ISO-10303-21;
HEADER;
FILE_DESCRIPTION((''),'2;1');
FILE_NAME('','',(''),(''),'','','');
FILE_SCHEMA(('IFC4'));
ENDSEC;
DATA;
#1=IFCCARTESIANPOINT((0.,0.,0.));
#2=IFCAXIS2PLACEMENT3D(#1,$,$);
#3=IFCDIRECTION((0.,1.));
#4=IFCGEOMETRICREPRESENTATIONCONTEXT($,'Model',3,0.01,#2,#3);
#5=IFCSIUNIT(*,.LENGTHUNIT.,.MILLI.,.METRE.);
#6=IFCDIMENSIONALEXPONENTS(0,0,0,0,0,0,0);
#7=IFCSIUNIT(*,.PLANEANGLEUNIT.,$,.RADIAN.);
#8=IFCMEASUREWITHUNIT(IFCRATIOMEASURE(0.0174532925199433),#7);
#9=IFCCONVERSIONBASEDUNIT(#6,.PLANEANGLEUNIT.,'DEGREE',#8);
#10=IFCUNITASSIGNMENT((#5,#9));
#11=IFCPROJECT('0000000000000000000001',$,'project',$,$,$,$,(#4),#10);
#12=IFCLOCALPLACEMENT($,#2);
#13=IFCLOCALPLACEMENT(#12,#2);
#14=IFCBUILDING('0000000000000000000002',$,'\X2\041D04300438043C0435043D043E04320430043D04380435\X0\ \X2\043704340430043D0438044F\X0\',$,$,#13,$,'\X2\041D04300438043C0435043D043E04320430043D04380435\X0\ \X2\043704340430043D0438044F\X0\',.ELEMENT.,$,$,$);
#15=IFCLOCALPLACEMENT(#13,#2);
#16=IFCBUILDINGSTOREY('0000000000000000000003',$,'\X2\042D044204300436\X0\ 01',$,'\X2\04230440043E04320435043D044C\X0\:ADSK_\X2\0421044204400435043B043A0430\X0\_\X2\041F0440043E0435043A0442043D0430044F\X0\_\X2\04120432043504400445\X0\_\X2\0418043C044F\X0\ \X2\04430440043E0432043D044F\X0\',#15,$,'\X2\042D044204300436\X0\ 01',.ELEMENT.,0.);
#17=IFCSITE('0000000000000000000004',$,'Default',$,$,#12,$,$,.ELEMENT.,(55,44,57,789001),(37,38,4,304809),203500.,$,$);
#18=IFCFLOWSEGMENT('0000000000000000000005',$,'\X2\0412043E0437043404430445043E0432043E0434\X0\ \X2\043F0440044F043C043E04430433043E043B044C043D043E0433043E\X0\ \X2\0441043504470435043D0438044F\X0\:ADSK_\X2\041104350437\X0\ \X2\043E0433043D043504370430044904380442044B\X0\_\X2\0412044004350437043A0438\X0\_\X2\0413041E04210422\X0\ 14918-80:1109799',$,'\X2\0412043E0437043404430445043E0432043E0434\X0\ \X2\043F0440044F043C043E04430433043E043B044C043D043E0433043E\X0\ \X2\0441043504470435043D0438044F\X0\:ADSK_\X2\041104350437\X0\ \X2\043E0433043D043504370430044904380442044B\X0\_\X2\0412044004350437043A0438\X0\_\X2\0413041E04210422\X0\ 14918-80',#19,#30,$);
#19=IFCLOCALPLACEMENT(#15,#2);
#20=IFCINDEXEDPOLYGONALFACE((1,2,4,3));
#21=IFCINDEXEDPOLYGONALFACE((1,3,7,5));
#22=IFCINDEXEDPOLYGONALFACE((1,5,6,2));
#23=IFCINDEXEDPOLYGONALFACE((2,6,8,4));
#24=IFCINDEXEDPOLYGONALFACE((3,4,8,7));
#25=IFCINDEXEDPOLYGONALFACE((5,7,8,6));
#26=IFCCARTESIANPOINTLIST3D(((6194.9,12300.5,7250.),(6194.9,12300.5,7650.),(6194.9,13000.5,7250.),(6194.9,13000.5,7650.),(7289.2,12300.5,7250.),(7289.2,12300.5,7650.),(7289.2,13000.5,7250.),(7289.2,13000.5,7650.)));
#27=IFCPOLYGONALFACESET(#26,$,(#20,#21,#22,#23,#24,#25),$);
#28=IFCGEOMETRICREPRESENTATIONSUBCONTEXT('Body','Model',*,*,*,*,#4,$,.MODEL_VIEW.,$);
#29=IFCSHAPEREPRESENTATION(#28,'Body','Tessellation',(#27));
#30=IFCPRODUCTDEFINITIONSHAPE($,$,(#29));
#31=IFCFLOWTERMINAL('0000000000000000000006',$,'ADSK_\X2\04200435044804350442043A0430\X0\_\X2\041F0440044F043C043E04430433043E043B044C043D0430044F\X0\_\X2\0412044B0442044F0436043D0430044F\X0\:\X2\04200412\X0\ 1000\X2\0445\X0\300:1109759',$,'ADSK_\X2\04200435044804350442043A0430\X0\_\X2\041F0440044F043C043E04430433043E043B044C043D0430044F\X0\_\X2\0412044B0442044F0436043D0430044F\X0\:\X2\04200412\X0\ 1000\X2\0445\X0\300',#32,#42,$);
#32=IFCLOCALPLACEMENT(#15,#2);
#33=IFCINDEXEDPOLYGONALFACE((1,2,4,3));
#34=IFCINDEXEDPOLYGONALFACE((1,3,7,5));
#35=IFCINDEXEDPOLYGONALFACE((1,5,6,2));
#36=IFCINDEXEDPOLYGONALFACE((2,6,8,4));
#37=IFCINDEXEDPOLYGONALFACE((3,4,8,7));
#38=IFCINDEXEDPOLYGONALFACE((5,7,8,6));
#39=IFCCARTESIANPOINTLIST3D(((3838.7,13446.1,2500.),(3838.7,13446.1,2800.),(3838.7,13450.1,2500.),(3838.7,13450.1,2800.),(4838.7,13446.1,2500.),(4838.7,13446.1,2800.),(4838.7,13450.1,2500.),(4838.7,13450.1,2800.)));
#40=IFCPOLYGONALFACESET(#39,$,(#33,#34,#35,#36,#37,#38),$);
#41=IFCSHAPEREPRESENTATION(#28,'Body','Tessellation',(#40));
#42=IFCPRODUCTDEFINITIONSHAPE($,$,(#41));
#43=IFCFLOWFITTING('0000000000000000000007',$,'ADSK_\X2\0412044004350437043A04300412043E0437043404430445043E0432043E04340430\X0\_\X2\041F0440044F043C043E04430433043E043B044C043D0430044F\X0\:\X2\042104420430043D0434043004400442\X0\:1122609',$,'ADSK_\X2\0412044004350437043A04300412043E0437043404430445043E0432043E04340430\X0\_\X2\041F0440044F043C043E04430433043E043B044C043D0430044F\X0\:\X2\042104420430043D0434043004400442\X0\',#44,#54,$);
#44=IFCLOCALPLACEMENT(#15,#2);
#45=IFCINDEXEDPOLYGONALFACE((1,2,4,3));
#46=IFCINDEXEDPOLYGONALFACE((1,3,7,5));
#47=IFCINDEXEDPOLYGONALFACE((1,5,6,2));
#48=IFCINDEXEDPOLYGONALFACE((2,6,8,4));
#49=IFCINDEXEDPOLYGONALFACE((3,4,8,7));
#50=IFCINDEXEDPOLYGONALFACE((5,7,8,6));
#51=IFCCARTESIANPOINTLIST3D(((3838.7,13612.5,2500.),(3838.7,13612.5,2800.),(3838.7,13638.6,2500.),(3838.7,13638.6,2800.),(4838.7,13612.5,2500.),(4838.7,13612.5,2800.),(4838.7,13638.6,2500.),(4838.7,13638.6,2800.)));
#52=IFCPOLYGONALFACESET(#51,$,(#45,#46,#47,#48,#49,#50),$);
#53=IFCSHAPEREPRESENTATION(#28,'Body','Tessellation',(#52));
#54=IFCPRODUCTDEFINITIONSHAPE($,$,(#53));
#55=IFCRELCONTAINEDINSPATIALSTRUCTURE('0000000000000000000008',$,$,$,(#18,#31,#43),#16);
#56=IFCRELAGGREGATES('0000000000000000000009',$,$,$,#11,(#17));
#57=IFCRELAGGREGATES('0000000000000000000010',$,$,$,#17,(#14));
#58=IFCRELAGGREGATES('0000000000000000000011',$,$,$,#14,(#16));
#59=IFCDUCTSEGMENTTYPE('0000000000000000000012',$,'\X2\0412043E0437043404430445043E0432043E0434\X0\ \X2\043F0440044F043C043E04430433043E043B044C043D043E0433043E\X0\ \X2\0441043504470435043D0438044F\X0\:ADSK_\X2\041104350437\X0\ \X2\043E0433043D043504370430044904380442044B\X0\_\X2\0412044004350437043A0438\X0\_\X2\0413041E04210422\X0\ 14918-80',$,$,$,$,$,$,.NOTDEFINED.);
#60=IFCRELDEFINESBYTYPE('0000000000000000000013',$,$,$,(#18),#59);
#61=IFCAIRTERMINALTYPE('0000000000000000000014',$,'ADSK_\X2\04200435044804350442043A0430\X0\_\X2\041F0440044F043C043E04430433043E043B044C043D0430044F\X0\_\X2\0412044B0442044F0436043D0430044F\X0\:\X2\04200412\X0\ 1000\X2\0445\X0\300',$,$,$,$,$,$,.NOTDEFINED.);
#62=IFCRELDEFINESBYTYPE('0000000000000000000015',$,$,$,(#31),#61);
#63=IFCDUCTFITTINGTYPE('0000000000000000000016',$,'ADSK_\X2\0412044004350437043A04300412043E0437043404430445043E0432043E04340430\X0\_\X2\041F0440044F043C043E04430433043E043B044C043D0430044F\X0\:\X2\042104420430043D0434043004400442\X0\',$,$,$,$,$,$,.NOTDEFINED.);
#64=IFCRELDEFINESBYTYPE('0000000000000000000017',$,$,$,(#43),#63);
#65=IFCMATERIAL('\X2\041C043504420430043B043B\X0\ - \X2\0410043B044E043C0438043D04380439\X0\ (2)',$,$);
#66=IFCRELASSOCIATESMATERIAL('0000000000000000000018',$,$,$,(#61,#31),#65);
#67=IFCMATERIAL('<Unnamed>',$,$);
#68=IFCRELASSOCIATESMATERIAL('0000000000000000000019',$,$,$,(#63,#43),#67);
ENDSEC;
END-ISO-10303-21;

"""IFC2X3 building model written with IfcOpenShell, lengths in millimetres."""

from ifc_helpers import new_model, entity, si_unit, converted_unit, direction, frame, frame_2d, origin, origin_2d_with_axis, place, context, subcontext, project, spatial, rectangle, extrude, source, transform, mapped, material, type_object, type_shapes, element, save


model = new_model("IFC2X3")

# Units and contexts
model_context = context("Model", 3, precision=0.01, world=origin(), true_north=direction((0.0, 1.0)))
body_context = subcontext(model_context, "Body", "Model", "MODEL_VIEW")
ifc_project = project(units=[si_unit("LENGTHUNIT", "METRE", prefix="MILLI"), converted_unit("PLANEANGLEUNIT", "DEGREE", entity("IfcRatioMeasure", 0.0174532925199433), si_unit("PLANEANGLEUNIT", "RADIAN"), dimensions=[0, 0, 0, 0, 0, 0, 0])], contexts=[model_context])

# Site, building, storey
site_placement = place(None, frame((0.0, 0.0, 0.0)))
site = spatial("IfcSite", under=ifc_project, at=site_placement, Name="Default", CompositionType="ELEMENT", RefLatitude=(55, 44, 57, 789001), RefLongitude=(37, 38, 4, 304809), RefElevation=203500.0)
building_placement = place(site_placement, origin())
building = spatial("IfcBuilding", under=site, at=building_placement, Name="Наименование здания", LongName="Наименование здания", CompositionType="ELEMENT")
storey_placement = place(building_placement, origin())
storey = spatial("IfcBuildingStorey", under=building, at=storey_placement, Name="Этаж 01", ObjectType="Уровень:ADSK_Стрелка_Проектная_Вверх_Имя уровня", LongName="Этаж 01", CompositionType="ELEMENT", Elevation=0.0)

# Shared definitions
ifc_material_1 = material(Name="<Unnamed>")

# Flow segment
duct_segment_type_1 = type_object("IfcDuctSegmentType", Name="Воздуховод прямоугольного сечения:ADSK_Без огнезащиты_Врезки_ГОСТ 14918-80", PredefinedType="NOTDEFINED")
flow_segment_1_placement = place(storey_placement, frame((6194.9, 12300.5, 7250.0)))
element("IfcFlowSegment", 1, at=flow_segment_1_placement, inside=storey, type_object=duct_segment_type_1, Name="Воздуховод прямоугольного сечения:ADSK_Без огнезащиты_Врезки_ГОСТ 14918-80:1109799", ObjectType="Воздуховод прямоугольного сечения:ADSK_Без огнезащиты_Врезки_ГОСТ 14918-80", context=body_context, shape_type="SweptSolid", body=[
    extrude(rectangle(XDim=1094.2, YDim=700.0, at=frame_2d((0.0, 0.0), x_axis=(1.0, 0.0))), frame((547.1, 350.0, 0.0), z_axis=(0.0, 0.0, 1.0), x_axis=(-1.0, 0.0, 0.0)), (0.0, 0.0, 1.0), 400.0),
])

# Flow terminal
ifc_material_2 = material(Name="Металл - Алюминий (2)")
air_terminal_type = type_object("IfcAirTerminalType", Name="ADSK_Решетка_Прямоугольная_Вытяжная:РВ 1000х300", PredefinedType="NOTDEFINED", material=ifc_material_2)
shared_shape_1 = source(origin(), body_context, "Body", "SweptSolid", [
    extrude(rectangle(XDim=4.0, YDim=1000.0, at=origin_2d_with_axis()), frame((0.0, -2.0, -150.0), z_axis=(0.0, 0.0, 1.0), x_axis=(0.0, 1.0, 0.0)), (0.0, 0.0, 1.0), 300.0),
])
type_shapes(air_terminal_type, [shared_shape_1])
flow_terminal_placement = place(storey_placement, frame((4338.7, 13450.1, 2650.0)))
element("IfcFlowTerminal", 2, at=flow_terminal_placement, inside=storey, type_object=air_terminal_type, material=ifc_material_2, Name="ADSK_Решетка_Прямоугольная_Вытяжная:РВ 1000х300:1109759", ObjectType="ADSK_Решетка_Прямоугольная_Вытяжная:РВ 1000х300", context=body_context, shape_type="MappedRepresentation", body=[
    mapped(shared_shape_1, transform((0.0, 0.0, 0.0), scale=1.0)),
])

# Flow fitting
duct_fitting_type_1 = type_object("IfcDuctFittingType", Name="ADSK_ВрезкаВоздуховода_Прямоугольная:Стандарт", PredefinedType="NOTDEFINED", material=ifc_material_1)
shared_shape_2 = source(origin(), body_context, "Body", "SweptSolid", [
    extrude(rectangle(XDim=26.1, YDim=1000.0, at=frame_2d((0.0, 0.0), x_axis=(1.0, 0.0))), frame((7.0, 0.0, -150.0)), (0.0, 0.0, 1.0), 300.0),
])
type_shapes(duct_fitting_type_1, [shared_shape_2])
flow_fitting_1_placement = place(storey_placement, frame((4338.7, 13632.5, 2650.0), z_axis=(0.0, 0.0, -1.0), x_axis=(0.0, -1.0, 0.0)))
element("IfcFlowFitting", 3, at=flow_fitting_1_placement, inside=storey, type_object=duct_fitting_type_1, material=ifc_material_1, Name="ADSK_ВрезкаВоздуховода_Прямоугольная:Стандарт:1122609", ObjectType="ADSK_ВрезкаВоздуховода_Прямоугольная:Стандарт", context=body_context, shape_type="MappedRepresentation", body=[
    mapped(shared_shape_2, transform((0.0, 0.0, 0.0), scale=1.0)),
])

save(model, "model.ifc")
